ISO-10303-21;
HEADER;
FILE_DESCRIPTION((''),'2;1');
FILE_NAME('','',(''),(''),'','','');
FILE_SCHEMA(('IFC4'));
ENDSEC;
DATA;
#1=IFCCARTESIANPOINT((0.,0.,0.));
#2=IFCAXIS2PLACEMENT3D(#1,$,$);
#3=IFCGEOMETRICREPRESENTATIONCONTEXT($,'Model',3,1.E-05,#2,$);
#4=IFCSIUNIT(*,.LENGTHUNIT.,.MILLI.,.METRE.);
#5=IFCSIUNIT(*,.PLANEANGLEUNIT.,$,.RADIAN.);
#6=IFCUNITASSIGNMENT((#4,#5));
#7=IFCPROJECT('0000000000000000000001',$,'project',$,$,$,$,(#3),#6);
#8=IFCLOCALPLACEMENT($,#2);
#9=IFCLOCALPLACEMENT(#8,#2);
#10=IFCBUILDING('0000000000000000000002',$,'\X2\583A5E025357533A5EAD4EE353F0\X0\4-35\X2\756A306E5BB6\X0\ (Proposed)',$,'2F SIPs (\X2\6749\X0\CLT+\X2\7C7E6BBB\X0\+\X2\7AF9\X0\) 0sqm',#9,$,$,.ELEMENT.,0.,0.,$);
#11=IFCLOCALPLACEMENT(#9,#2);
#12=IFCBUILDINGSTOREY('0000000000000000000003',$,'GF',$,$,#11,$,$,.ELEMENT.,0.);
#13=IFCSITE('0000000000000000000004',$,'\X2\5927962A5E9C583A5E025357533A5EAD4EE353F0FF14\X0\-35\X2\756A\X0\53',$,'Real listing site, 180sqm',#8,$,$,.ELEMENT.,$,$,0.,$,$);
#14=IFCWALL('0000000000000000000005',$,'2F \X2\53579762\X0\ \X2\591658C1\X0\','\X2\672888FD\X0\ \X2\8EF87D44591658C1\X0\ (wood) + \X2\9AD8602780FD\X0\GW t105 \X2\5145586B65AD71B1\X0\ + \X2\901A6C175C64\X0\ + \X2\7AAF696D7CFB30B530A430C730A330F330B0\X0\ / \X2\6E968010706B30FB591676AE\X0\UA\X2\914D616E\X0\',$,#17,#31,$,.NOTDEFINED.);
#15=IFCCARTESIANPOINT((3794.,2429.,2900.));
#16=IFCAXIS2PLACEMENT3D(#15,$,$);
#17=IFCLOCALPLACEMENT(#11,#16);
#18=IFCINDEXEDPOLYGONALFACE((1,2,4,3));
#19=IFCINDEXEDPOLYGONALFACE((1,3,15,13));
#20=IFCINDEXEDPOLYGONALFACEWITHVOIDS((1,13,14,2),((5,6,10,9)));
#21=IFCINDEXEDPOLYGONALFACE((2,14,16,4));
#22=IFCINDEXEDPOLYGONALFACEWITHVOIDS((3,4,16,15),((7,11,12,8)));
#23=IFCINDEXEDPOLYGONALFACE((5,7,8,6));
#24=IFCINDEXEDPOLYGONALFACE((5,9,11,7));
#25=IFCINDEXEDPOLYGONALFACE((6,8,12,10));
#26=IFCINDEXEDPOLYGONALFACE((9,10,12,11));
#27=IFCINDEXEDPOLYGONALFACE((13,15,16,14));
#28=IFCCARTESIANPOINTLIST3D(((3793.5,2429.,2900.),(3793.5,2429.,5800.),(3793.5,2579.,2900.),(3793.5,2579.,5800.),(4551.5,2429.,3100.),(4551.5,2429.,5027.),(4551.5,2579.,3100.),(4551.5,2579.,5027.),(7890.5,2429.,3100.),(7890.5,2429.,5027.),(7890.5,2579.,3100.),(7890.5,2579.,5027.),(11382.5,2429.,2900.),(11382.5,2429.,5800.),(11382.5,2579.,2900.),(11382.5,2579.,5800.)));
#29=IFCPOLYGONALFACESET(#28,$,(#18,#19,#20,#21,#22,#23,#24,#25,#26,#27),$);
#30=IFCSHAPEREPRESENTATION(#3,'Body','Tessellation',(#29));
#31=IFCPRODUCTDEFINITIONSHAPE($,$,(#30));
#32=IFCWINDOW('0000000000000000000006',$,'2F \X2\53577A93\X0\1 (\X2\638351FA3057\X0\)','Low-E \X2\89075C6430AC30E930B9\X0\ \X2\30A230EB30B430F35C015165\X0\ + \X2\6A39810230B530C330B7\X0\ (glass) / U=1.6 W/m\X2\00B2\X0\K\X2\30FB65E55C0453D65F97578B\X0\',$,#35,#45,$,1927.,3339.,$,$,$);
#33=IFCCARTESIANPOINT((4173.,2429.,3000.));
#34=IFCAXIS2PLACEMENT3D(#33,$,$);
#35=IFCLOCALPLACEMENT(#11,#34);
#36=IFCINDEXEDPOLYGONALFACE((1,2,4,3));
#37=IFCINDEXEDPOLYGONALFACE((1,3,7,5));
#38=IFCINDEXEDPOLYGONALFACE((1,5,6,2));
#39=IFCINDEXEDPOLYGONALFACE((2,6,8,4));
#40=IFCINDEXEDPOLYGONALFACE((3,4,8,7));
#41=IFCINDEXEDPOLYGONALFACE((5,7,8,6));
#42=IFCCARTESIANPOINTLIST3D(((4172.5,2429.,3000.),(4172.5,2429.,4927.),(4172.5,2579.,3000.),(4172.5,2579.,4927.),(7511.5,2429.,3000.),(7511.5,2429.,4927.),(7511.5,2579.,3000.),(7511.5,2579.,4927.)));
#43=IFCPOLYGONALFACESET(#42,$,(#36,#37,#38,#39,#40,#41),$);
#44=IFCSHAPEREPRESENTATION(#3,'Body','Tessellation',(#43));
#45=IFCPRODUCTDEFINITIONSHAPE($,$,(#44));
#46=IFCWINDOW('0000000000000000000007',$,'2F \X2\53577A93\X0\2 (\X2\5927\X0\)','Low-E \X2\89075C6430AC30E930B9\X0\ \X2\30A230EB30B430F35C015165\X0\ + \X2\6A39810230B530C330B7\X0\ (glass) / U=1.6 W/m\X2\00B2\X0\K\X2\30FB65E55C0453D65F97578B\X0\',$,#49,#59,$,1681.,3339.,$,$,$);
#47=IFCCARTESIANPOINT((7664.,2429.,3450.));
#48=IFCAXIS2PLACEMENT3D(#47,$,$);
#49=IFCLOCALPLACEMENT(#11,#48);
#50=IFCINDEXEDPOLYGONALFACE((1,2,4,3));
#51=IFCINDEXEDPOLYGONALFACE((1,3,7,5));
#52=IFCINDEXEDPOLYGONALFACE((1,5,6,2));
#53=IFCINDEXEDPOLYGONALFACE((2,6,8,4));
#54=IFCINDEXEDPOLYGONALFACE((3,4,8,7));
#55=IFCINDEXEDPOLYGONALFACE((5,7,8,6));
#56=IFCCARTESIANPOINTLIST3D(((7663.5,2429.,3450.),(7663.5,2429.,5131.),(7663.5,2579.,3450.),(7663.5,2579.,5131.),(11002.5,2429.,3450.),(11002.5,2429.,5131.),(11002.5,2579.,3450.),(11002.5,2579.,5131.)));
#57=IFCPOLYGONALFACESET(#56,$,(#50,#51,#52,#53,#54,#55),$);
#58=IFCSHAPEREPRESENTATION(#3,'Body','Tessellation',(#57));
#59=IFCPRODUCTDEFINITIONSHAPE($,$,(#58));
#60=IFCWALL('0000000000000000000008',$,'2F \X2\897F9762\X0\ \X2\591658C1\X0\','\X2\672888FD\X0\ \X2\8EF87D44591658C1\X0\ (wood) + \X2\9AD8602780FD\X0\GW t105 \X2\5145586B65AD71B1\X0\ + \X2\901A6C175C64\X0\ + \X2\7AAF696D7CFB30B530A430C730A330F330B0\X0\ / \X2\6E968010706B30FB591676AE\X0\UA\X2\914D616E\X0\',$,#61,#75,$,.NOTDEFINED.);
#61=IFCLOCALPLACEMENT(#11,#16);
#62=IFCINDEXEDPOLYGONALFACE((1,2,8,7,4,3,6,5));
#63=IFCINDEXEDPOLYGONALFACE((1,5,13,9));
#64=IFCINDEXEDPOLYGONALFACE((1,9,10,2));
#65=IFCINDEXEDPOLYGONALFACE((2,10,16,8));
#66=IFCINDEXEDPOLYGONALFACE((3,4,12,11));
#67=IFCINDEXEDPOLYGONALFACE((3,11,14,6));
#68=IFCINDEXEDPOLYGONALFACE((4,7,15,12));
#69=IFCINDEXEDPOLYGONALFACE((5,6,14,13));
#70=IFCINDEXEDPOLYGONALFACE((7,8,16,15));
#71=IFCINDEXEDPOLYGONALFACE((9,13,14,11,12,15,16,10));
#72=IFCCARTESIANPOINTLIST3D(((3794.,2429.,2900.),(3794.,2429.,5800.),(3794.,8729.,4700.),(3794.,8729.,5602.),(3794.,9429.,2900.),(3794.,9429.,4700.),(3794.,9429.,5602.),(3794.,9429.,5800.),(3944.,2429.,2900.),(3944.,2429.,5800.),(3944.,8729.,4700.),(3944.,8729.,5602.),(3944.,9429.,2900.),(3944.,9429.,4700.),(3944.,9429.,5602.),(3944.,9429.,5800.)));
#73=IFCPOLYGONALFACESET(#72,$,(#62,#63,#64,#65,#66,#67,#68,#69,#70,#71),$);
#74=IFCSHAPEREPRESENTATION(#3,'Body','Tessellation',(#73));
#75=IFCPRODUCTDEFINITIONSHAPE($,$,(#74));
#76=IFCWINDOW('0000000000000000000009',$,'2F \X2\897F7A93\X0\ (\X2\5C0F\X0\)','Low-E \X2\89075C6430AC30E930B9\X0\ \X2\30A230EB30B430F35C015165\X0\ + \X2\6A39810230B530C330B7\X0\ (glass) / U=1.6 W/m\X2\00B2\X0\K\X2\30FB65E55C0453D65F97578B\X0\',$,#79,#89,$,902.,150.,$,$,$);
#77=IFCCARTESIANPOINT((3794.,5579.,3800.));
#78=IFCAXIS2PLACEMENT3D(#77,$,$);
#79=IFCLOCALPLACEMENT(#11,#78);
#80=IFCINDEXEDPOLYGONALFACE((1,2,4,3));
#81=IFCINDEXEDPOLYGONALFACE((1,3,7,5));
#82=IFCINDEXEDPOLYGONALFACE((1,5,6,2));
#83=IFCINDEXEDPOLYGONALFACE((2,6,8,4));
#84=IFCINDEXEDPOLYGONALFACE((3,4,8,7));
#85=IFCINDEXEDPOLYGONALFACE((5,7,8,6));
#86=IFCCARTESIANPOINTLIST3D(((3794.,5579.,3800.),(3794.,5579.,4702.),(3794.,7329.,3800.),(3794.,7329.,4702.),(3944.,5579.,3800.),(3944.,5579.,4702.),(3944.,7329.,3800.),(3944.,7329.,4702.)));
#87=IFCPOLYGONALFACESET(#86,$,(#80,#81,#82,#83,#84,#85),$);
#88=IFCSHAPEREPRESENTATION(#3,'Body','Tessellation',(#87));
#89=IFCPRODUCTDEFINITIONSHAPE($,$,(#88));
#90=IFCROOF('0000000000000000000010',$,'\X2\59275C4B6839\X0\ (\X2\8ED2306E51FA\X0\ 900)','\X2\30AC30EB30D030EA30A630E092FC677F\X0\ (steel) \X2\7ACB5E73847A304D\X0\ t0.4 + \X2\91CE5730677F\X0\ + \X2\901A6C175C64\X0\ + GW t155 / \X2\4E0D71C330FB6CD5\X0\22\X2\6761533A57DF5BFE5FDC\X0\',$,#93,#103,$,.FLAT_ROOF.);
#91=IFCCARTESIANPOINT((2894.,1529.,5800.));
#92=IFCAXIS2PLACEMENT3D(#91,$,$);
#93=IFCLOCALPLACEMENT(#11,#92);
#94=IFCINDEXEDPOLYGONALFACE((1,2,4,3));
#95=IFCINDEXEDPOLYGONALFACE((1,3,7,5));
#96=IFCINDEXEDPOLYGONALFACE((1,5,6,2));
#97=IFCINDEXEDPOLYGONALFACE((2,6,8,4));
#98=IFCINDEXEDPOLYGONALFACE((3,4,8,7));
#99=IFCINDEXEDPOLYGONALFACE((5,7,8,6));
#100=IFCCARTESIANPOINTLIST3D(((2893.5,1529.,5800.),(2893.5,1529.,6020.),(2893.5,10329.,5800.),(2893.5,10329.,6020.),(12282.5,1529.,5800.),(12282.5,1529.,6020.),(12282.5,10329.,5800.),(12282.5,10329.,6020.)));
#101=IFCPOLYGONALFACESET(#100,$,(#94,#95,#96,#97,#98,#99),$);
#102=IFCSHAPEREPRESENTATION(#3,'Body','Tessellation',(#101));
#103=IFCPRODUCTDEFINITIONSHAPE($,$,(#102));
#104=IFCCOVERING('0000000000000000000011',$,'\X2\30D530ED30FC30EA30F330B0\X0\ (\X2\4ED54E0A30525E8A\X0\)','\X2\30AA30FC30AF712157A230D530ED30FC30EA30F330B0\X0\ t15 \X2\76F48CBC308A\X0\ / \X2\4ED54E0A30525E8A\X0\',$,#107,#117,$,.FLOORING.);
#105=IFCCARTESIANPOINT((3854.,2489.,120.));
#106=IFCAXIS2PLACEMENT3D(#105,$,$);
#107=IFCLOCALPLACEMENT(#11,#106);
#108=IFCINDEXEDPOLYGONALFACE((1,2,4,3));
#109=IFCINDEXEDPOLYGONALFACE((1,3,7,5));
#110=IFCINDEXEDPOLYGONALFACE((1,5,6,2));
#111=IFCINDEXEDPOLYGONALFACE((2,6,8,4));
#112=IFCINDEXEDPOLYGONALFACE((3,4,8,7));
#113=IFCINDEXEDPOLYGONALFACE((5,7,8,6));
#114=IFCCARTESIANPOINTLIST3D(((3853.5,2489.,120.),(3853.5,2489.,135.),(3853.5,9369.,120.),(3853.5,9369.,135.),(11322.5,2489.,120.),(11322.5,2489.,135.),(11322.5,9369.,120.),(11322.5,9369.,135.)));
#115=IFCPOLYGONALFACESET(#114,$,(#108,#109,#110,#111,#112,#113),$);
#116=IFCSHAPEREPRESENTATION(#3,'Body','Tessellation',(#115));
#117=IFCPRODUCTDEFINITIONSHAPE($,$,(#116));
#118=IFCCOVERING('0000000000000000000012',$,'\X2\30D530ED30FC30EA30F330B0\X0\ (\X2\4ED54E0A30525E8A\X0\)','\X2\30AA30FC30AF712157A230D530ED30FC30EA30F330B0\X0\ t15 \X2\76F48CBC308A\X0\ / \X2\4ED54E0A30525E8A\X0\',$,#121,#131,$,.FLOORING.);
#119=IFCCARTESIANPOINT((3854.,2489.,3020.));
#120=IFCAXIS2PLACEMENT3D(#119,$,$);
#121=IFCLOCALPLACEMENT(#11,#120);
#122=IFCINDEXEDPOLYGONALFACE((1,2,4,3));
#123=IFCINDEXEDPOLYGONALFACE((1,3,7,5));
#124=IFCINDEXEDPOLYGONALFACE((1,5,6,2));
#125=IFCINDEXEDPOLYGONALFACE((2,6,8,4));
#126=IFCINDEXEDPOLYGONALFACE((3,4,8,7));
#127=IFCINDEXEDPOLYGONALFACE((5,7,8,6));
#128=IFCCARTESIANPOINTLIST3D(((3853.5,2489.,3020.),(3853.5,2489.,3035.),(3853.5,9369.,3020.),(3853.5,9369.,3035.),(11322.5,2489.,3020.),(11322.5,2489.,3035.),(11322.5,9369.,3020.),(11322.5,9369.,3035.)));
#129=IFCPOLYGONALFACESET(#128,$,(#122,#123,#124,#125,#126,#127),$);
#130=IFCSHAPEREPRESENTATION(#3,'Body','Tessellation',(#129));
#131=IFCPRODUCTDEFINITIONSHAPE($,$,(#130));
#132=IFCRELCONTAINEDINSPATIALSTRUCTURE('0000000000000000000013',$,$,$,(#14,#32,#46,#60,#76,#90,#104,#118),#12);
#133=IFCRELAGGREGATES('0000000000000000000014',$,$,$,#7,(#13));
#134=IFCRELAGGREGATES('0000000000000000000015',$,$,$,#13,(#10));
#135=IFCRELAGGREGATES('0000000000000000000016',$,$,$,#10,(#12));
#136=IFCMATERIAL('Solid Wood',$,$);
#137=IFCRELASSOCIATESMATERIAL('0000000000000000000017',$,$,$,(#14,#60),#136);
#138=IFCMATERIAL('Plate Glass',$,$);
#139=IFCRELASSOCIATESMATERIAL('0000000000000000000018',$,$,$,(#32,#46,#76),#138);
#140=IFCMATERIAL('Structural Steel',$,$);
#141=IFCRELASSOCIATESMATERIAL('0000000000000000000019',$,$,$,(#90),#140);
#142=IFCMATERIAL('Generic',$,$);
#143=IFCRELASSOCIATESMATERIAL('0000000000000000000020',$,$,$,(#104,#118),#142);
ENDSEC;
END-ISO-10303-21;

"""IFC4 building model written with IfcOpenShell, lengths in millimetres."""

from ifc_helpers import new_model, si_unit, frame, frame_2d, origin, place, context, project, spatial, rectangle, extrude, material, element, fill, save


model = new_model("IFC4")

# Units and contexts
model_context = context("Model", 3, precision=1e-05, world=origin())
ifc_project = project(units=[si_unit("LENGTHUNIT", "METRE", prefix="MILLI"), si_unit("PLANEANGLEUNIT", "RADIAN")], contexts=[model_context])

# Site, building, storey
site_placement = place(None, origin())
site = spatial("IfcSite", under=ifc_project, at=site_placement, Name="大阪府堺市南区庭代台４-35番53", ObjectType="Real listing site, 180sqm", CompositionType="ELEMENT", RefElevation=0.0)
building_placement = place(site_placement, origin())
building = spatial("IfcBuilding", under=site, at=building_placement, Name="堺市南区庭代台4-35番の家 (Proposed)", ObjectType="2F SIPs (杉CLT+籾殻+竹) 0sqm", CompositionType="ELEMENT", ElevationOfRefHeight=0.0, ElevationOfTerrain=0.0)
storey_placement = place(building_placement, origin())
storey = spatial("IfcBuildingStorey", under=building, at=storey_placement, Name="GF", CompositionType="ELEMENT", Elevation=0.0)

# Shared definitions
ifc_material_1 = material(Name="Solid Wood")

# Shared definitions
ifc_material_2 = material(Name="Plate Glass")

# Wall, openings, windows
wall_1_placement = place(storey_placement, frame((3794.0, 2429.0, 2900.0)))
wall_1 = element("IfcWall", 1, at=wall_1_placement, inside=storey, material=ifc_material_1, Name="2F 南面 外壁", Description="木製 軸組外壁 (wood) + 高性能GW t105 充填断熱 + 通気層 + 窯業系サイディング / 準耐火・外皮UA配慮", PredefinedType="NOTDEFINED", context=model_context, shape_type="SweptSolid", body=[
    extrude(rectangle(XDim=7589.0, YDim=150.0, at=frame_2d((3794.0, 75.0))), frame((3794.0, 2429.0, 2900.0)), (0.0, 0.0, 1.0), 2900.0),
])
opening_1_placement = place(storey_placement, frame((4173.0, 2429.0, 3000.0)))
opening_1 = element("IfcOpeningElement", 2, at=opening_1_placement, cuts=wall_1, PredefinedType="NOTDEFINED", context=model_context, shape_type="SweptSolid", body=[
    extrude(rectangle(XDim=3339.0, YDim=150.0, at=frame_2d((1669.0, 75.0))), frame((4173.0, 2429.0, 3000.0)), (0.0, 0.0, 1.0), 1927.0),
])
opening_2_placement = place(storey_placement, frame((7664.0, 2429.0, 3450.0)))
opening_2 = element("IfcOpeningElement", 3, at=opening_2_placement, cuts=wall_1, PredefinedType="NOTDEFINED", context=model_context, shape_type="SweptSolid", body=[
    extrude(rectangle(XDim=3339.0, YDim=150.0, at=frame_2d((1669.0, 75.0))), frame((7664.0, 2429.0, 3450.0)), (0.0, 0.0, 1.0), 1681.0),
])
window_1_placement = place(storey_placement, frame((4173.0, 2429.0, 3000.0)))
window_1 = element("IfcWindow", 4, at=window_1_placement, inside=storey, material=ifc_material_2, Name="2F 南窓1 (掃出し)", Description="Low-E 複層ガラス アルゴン封入 + 樹脂サッシ (glass) / U=1.6 W/m²K・日射取得型", OverallHeight=1927.0, OverallWidth=3339.0, context=model_context, shape_type="SweptSolid", body=[
    extrude(rectangle(XDim=3339.0, YDim=150.0, at=frame_2d((1669.0, 75.0))), frame((4173.0, 2429.0, 3000.0)), (0.0, 0.0, 1.0), 1927.0),
])
fill(opening_1, window_1)
window_2_placement = place(storey_placement, frame((7664.0, 2429.0, 3450.0)))
window_2 = element("IfcWindow", 5, at=window_2_placement, inside=storey, material=ifc_material_2, Name="2F 南窓2 (大)", Description="Low-E 複層ガラス アルゴン封入 + 樹脂サッシ (glass) / U=1.6 W/m²K・日射取得型", OverallHeight=1681.0, OverallWidth=3339.0, context=model_context, shape_type="SweptSolid", body=[
    extrude(rectangle(XDim=3339.0, YDim=150.0, at=frame_2d((1669.0, 75.0))), frame((7664.0, 2429.0, 3450.0)), (0.0, 0.0, 1.0), 1681.0),
])
fill(opening_2, window_2)

# Wall, opening, window
wall_2_placement = place(storey_placement, frame((3794.0, 2429.0, 2900.0)))
wall_2 = element("IfcWall", 6, at=wall_2_placement, inside=storey, material=ifc_material_1, Name="2F 西面 外壁", Description="木製 軸組外壁 (wood) + 高性能GW t105 充填断熱 + 通気層 + 窯業系サイディング / 準耐火・外皮UA配慮", PredefinedType="NOTDEFINED", context=model_context, shape_type="SweptSolid", body=[
    extrude(rectangle(XDim=150.0, YDim=7000.0, at=frame_2d((75.0, 3500.0))), frame((3794.0, 2429.0, 2900.0)), (0.0, 0.0, 1.0), 2900.0),
])
opening_3_placement = place(storey_placement, frame((3794.0, 5579.0, 3800.0)))
opening_3 = element("IfcOpeningElement", 7, at=opening_3_placement, cuts=wall_2, PredefinedType="NOTDEFINED", context=model_context, shape_type="SweptSolid", body=[
    extrude(rectangle(XDim=150.0, YDim=1750.0, at=frame_2d((75.0, 875.0))), frame((3794.0, 5579.0, 3800.0)), (0.0, 0.0, 1.0), 902.0),
])
window_3_placement = place(storey_placement, frame((3794.0, 5579.0, 3800.0)))
window_3 = element("IfcWindow", 8, at=window_3_placement, inside=storey, material=ifc_material_2, Name="2F 西窓 (小)", Description="Low-E 複層ガラス アルゴン封入 + 樹脂サッシ (glass) / U=1.6 W/m²K・日射取得型", OverallHeight=902.0, OverallWidth=150.0, context=model_context, shape_type="SweptSolid", body=[
    extrude(rectangle(XDim=150.0, YDim=1750.0, at=frame_2d((75.0, 875.0))), frame((3794.0, 5579.0, 3800.0)), (0.0, 0.0, 1.0), 902.0),
])
fill(opening_3, window_3)

# Roof
ifc_material_3 = material(Name="Structural Steel")
roof_placement = place(storey_placement, frame((2894.0, 1529.0, 5800.0)))
element("IfcRoof", 9, at=roof_placement, inside=storey, material=ifc_material_3, Name="大屋根 (軒の出 900)", Description="ガルバリウム鋼板 (steel) 立平葺き t0.4 + 野地板 + 通気層 + GW t155 / 不燃・法22条区域対応", PredefinedType="FLAT_ROOF", context=model_context, shape_type="SweptSolid", body=[
    extrude(rectangle(XDim=9389.0, YDim=8800.0, at=frame_2d((4694.0, 4400.0))), frame((2894.0, 1529.0, 5800.0)), (0.0, 0.0, 1.0), 220.0),
])

# Coverings
ifc_material_4 = material(Name="Generic")
covering_1_placement = place(storey_placement, frame((3854.0, 2489.0, 120.0)))
element("IfcCovering", 10, at=covering_1_placement, inside=storey, material=ifc_material_4, Name="フローリング (仕上げ床)", Description="オーク無垢フローリング t15 直貼り / 仕上げ床", PredefinedType="FLOORING", context=model_context, shape_type="SweptSolid", body=[
    extrude(rectangle(XDim=7469.0, YDim=6880.0, at=frame_2d((3734.0, 3440.0))), frame((3854.0, 2489.0, 120.0)), (0.0, 0.0, 1.0), 15.0),
])
covering_2_placement = place(storey_placement, frame((3854.0, 2489.0, 3020.0)))
element("IfcCovering", 11, at=covering_2_placement, inside=storey, material=ifc_material_4, Name="フローリング (仕上げ床)", Description="オーク無垢フローリング t15 直貼り / 仕上げ床", PredefinedType="FLOORING", context=model_context, shape_type="SweptSolid", body=[
    extrude(rectangle(XDim=7469.0, YDim=6880.0, at=frame_2d((3734.0, 3440.0))), frame((3854.0, 2489.0, 3020.0)), (0.0, 0.0, 1.0), 15.0),
])

save(model, "model.ifc")
